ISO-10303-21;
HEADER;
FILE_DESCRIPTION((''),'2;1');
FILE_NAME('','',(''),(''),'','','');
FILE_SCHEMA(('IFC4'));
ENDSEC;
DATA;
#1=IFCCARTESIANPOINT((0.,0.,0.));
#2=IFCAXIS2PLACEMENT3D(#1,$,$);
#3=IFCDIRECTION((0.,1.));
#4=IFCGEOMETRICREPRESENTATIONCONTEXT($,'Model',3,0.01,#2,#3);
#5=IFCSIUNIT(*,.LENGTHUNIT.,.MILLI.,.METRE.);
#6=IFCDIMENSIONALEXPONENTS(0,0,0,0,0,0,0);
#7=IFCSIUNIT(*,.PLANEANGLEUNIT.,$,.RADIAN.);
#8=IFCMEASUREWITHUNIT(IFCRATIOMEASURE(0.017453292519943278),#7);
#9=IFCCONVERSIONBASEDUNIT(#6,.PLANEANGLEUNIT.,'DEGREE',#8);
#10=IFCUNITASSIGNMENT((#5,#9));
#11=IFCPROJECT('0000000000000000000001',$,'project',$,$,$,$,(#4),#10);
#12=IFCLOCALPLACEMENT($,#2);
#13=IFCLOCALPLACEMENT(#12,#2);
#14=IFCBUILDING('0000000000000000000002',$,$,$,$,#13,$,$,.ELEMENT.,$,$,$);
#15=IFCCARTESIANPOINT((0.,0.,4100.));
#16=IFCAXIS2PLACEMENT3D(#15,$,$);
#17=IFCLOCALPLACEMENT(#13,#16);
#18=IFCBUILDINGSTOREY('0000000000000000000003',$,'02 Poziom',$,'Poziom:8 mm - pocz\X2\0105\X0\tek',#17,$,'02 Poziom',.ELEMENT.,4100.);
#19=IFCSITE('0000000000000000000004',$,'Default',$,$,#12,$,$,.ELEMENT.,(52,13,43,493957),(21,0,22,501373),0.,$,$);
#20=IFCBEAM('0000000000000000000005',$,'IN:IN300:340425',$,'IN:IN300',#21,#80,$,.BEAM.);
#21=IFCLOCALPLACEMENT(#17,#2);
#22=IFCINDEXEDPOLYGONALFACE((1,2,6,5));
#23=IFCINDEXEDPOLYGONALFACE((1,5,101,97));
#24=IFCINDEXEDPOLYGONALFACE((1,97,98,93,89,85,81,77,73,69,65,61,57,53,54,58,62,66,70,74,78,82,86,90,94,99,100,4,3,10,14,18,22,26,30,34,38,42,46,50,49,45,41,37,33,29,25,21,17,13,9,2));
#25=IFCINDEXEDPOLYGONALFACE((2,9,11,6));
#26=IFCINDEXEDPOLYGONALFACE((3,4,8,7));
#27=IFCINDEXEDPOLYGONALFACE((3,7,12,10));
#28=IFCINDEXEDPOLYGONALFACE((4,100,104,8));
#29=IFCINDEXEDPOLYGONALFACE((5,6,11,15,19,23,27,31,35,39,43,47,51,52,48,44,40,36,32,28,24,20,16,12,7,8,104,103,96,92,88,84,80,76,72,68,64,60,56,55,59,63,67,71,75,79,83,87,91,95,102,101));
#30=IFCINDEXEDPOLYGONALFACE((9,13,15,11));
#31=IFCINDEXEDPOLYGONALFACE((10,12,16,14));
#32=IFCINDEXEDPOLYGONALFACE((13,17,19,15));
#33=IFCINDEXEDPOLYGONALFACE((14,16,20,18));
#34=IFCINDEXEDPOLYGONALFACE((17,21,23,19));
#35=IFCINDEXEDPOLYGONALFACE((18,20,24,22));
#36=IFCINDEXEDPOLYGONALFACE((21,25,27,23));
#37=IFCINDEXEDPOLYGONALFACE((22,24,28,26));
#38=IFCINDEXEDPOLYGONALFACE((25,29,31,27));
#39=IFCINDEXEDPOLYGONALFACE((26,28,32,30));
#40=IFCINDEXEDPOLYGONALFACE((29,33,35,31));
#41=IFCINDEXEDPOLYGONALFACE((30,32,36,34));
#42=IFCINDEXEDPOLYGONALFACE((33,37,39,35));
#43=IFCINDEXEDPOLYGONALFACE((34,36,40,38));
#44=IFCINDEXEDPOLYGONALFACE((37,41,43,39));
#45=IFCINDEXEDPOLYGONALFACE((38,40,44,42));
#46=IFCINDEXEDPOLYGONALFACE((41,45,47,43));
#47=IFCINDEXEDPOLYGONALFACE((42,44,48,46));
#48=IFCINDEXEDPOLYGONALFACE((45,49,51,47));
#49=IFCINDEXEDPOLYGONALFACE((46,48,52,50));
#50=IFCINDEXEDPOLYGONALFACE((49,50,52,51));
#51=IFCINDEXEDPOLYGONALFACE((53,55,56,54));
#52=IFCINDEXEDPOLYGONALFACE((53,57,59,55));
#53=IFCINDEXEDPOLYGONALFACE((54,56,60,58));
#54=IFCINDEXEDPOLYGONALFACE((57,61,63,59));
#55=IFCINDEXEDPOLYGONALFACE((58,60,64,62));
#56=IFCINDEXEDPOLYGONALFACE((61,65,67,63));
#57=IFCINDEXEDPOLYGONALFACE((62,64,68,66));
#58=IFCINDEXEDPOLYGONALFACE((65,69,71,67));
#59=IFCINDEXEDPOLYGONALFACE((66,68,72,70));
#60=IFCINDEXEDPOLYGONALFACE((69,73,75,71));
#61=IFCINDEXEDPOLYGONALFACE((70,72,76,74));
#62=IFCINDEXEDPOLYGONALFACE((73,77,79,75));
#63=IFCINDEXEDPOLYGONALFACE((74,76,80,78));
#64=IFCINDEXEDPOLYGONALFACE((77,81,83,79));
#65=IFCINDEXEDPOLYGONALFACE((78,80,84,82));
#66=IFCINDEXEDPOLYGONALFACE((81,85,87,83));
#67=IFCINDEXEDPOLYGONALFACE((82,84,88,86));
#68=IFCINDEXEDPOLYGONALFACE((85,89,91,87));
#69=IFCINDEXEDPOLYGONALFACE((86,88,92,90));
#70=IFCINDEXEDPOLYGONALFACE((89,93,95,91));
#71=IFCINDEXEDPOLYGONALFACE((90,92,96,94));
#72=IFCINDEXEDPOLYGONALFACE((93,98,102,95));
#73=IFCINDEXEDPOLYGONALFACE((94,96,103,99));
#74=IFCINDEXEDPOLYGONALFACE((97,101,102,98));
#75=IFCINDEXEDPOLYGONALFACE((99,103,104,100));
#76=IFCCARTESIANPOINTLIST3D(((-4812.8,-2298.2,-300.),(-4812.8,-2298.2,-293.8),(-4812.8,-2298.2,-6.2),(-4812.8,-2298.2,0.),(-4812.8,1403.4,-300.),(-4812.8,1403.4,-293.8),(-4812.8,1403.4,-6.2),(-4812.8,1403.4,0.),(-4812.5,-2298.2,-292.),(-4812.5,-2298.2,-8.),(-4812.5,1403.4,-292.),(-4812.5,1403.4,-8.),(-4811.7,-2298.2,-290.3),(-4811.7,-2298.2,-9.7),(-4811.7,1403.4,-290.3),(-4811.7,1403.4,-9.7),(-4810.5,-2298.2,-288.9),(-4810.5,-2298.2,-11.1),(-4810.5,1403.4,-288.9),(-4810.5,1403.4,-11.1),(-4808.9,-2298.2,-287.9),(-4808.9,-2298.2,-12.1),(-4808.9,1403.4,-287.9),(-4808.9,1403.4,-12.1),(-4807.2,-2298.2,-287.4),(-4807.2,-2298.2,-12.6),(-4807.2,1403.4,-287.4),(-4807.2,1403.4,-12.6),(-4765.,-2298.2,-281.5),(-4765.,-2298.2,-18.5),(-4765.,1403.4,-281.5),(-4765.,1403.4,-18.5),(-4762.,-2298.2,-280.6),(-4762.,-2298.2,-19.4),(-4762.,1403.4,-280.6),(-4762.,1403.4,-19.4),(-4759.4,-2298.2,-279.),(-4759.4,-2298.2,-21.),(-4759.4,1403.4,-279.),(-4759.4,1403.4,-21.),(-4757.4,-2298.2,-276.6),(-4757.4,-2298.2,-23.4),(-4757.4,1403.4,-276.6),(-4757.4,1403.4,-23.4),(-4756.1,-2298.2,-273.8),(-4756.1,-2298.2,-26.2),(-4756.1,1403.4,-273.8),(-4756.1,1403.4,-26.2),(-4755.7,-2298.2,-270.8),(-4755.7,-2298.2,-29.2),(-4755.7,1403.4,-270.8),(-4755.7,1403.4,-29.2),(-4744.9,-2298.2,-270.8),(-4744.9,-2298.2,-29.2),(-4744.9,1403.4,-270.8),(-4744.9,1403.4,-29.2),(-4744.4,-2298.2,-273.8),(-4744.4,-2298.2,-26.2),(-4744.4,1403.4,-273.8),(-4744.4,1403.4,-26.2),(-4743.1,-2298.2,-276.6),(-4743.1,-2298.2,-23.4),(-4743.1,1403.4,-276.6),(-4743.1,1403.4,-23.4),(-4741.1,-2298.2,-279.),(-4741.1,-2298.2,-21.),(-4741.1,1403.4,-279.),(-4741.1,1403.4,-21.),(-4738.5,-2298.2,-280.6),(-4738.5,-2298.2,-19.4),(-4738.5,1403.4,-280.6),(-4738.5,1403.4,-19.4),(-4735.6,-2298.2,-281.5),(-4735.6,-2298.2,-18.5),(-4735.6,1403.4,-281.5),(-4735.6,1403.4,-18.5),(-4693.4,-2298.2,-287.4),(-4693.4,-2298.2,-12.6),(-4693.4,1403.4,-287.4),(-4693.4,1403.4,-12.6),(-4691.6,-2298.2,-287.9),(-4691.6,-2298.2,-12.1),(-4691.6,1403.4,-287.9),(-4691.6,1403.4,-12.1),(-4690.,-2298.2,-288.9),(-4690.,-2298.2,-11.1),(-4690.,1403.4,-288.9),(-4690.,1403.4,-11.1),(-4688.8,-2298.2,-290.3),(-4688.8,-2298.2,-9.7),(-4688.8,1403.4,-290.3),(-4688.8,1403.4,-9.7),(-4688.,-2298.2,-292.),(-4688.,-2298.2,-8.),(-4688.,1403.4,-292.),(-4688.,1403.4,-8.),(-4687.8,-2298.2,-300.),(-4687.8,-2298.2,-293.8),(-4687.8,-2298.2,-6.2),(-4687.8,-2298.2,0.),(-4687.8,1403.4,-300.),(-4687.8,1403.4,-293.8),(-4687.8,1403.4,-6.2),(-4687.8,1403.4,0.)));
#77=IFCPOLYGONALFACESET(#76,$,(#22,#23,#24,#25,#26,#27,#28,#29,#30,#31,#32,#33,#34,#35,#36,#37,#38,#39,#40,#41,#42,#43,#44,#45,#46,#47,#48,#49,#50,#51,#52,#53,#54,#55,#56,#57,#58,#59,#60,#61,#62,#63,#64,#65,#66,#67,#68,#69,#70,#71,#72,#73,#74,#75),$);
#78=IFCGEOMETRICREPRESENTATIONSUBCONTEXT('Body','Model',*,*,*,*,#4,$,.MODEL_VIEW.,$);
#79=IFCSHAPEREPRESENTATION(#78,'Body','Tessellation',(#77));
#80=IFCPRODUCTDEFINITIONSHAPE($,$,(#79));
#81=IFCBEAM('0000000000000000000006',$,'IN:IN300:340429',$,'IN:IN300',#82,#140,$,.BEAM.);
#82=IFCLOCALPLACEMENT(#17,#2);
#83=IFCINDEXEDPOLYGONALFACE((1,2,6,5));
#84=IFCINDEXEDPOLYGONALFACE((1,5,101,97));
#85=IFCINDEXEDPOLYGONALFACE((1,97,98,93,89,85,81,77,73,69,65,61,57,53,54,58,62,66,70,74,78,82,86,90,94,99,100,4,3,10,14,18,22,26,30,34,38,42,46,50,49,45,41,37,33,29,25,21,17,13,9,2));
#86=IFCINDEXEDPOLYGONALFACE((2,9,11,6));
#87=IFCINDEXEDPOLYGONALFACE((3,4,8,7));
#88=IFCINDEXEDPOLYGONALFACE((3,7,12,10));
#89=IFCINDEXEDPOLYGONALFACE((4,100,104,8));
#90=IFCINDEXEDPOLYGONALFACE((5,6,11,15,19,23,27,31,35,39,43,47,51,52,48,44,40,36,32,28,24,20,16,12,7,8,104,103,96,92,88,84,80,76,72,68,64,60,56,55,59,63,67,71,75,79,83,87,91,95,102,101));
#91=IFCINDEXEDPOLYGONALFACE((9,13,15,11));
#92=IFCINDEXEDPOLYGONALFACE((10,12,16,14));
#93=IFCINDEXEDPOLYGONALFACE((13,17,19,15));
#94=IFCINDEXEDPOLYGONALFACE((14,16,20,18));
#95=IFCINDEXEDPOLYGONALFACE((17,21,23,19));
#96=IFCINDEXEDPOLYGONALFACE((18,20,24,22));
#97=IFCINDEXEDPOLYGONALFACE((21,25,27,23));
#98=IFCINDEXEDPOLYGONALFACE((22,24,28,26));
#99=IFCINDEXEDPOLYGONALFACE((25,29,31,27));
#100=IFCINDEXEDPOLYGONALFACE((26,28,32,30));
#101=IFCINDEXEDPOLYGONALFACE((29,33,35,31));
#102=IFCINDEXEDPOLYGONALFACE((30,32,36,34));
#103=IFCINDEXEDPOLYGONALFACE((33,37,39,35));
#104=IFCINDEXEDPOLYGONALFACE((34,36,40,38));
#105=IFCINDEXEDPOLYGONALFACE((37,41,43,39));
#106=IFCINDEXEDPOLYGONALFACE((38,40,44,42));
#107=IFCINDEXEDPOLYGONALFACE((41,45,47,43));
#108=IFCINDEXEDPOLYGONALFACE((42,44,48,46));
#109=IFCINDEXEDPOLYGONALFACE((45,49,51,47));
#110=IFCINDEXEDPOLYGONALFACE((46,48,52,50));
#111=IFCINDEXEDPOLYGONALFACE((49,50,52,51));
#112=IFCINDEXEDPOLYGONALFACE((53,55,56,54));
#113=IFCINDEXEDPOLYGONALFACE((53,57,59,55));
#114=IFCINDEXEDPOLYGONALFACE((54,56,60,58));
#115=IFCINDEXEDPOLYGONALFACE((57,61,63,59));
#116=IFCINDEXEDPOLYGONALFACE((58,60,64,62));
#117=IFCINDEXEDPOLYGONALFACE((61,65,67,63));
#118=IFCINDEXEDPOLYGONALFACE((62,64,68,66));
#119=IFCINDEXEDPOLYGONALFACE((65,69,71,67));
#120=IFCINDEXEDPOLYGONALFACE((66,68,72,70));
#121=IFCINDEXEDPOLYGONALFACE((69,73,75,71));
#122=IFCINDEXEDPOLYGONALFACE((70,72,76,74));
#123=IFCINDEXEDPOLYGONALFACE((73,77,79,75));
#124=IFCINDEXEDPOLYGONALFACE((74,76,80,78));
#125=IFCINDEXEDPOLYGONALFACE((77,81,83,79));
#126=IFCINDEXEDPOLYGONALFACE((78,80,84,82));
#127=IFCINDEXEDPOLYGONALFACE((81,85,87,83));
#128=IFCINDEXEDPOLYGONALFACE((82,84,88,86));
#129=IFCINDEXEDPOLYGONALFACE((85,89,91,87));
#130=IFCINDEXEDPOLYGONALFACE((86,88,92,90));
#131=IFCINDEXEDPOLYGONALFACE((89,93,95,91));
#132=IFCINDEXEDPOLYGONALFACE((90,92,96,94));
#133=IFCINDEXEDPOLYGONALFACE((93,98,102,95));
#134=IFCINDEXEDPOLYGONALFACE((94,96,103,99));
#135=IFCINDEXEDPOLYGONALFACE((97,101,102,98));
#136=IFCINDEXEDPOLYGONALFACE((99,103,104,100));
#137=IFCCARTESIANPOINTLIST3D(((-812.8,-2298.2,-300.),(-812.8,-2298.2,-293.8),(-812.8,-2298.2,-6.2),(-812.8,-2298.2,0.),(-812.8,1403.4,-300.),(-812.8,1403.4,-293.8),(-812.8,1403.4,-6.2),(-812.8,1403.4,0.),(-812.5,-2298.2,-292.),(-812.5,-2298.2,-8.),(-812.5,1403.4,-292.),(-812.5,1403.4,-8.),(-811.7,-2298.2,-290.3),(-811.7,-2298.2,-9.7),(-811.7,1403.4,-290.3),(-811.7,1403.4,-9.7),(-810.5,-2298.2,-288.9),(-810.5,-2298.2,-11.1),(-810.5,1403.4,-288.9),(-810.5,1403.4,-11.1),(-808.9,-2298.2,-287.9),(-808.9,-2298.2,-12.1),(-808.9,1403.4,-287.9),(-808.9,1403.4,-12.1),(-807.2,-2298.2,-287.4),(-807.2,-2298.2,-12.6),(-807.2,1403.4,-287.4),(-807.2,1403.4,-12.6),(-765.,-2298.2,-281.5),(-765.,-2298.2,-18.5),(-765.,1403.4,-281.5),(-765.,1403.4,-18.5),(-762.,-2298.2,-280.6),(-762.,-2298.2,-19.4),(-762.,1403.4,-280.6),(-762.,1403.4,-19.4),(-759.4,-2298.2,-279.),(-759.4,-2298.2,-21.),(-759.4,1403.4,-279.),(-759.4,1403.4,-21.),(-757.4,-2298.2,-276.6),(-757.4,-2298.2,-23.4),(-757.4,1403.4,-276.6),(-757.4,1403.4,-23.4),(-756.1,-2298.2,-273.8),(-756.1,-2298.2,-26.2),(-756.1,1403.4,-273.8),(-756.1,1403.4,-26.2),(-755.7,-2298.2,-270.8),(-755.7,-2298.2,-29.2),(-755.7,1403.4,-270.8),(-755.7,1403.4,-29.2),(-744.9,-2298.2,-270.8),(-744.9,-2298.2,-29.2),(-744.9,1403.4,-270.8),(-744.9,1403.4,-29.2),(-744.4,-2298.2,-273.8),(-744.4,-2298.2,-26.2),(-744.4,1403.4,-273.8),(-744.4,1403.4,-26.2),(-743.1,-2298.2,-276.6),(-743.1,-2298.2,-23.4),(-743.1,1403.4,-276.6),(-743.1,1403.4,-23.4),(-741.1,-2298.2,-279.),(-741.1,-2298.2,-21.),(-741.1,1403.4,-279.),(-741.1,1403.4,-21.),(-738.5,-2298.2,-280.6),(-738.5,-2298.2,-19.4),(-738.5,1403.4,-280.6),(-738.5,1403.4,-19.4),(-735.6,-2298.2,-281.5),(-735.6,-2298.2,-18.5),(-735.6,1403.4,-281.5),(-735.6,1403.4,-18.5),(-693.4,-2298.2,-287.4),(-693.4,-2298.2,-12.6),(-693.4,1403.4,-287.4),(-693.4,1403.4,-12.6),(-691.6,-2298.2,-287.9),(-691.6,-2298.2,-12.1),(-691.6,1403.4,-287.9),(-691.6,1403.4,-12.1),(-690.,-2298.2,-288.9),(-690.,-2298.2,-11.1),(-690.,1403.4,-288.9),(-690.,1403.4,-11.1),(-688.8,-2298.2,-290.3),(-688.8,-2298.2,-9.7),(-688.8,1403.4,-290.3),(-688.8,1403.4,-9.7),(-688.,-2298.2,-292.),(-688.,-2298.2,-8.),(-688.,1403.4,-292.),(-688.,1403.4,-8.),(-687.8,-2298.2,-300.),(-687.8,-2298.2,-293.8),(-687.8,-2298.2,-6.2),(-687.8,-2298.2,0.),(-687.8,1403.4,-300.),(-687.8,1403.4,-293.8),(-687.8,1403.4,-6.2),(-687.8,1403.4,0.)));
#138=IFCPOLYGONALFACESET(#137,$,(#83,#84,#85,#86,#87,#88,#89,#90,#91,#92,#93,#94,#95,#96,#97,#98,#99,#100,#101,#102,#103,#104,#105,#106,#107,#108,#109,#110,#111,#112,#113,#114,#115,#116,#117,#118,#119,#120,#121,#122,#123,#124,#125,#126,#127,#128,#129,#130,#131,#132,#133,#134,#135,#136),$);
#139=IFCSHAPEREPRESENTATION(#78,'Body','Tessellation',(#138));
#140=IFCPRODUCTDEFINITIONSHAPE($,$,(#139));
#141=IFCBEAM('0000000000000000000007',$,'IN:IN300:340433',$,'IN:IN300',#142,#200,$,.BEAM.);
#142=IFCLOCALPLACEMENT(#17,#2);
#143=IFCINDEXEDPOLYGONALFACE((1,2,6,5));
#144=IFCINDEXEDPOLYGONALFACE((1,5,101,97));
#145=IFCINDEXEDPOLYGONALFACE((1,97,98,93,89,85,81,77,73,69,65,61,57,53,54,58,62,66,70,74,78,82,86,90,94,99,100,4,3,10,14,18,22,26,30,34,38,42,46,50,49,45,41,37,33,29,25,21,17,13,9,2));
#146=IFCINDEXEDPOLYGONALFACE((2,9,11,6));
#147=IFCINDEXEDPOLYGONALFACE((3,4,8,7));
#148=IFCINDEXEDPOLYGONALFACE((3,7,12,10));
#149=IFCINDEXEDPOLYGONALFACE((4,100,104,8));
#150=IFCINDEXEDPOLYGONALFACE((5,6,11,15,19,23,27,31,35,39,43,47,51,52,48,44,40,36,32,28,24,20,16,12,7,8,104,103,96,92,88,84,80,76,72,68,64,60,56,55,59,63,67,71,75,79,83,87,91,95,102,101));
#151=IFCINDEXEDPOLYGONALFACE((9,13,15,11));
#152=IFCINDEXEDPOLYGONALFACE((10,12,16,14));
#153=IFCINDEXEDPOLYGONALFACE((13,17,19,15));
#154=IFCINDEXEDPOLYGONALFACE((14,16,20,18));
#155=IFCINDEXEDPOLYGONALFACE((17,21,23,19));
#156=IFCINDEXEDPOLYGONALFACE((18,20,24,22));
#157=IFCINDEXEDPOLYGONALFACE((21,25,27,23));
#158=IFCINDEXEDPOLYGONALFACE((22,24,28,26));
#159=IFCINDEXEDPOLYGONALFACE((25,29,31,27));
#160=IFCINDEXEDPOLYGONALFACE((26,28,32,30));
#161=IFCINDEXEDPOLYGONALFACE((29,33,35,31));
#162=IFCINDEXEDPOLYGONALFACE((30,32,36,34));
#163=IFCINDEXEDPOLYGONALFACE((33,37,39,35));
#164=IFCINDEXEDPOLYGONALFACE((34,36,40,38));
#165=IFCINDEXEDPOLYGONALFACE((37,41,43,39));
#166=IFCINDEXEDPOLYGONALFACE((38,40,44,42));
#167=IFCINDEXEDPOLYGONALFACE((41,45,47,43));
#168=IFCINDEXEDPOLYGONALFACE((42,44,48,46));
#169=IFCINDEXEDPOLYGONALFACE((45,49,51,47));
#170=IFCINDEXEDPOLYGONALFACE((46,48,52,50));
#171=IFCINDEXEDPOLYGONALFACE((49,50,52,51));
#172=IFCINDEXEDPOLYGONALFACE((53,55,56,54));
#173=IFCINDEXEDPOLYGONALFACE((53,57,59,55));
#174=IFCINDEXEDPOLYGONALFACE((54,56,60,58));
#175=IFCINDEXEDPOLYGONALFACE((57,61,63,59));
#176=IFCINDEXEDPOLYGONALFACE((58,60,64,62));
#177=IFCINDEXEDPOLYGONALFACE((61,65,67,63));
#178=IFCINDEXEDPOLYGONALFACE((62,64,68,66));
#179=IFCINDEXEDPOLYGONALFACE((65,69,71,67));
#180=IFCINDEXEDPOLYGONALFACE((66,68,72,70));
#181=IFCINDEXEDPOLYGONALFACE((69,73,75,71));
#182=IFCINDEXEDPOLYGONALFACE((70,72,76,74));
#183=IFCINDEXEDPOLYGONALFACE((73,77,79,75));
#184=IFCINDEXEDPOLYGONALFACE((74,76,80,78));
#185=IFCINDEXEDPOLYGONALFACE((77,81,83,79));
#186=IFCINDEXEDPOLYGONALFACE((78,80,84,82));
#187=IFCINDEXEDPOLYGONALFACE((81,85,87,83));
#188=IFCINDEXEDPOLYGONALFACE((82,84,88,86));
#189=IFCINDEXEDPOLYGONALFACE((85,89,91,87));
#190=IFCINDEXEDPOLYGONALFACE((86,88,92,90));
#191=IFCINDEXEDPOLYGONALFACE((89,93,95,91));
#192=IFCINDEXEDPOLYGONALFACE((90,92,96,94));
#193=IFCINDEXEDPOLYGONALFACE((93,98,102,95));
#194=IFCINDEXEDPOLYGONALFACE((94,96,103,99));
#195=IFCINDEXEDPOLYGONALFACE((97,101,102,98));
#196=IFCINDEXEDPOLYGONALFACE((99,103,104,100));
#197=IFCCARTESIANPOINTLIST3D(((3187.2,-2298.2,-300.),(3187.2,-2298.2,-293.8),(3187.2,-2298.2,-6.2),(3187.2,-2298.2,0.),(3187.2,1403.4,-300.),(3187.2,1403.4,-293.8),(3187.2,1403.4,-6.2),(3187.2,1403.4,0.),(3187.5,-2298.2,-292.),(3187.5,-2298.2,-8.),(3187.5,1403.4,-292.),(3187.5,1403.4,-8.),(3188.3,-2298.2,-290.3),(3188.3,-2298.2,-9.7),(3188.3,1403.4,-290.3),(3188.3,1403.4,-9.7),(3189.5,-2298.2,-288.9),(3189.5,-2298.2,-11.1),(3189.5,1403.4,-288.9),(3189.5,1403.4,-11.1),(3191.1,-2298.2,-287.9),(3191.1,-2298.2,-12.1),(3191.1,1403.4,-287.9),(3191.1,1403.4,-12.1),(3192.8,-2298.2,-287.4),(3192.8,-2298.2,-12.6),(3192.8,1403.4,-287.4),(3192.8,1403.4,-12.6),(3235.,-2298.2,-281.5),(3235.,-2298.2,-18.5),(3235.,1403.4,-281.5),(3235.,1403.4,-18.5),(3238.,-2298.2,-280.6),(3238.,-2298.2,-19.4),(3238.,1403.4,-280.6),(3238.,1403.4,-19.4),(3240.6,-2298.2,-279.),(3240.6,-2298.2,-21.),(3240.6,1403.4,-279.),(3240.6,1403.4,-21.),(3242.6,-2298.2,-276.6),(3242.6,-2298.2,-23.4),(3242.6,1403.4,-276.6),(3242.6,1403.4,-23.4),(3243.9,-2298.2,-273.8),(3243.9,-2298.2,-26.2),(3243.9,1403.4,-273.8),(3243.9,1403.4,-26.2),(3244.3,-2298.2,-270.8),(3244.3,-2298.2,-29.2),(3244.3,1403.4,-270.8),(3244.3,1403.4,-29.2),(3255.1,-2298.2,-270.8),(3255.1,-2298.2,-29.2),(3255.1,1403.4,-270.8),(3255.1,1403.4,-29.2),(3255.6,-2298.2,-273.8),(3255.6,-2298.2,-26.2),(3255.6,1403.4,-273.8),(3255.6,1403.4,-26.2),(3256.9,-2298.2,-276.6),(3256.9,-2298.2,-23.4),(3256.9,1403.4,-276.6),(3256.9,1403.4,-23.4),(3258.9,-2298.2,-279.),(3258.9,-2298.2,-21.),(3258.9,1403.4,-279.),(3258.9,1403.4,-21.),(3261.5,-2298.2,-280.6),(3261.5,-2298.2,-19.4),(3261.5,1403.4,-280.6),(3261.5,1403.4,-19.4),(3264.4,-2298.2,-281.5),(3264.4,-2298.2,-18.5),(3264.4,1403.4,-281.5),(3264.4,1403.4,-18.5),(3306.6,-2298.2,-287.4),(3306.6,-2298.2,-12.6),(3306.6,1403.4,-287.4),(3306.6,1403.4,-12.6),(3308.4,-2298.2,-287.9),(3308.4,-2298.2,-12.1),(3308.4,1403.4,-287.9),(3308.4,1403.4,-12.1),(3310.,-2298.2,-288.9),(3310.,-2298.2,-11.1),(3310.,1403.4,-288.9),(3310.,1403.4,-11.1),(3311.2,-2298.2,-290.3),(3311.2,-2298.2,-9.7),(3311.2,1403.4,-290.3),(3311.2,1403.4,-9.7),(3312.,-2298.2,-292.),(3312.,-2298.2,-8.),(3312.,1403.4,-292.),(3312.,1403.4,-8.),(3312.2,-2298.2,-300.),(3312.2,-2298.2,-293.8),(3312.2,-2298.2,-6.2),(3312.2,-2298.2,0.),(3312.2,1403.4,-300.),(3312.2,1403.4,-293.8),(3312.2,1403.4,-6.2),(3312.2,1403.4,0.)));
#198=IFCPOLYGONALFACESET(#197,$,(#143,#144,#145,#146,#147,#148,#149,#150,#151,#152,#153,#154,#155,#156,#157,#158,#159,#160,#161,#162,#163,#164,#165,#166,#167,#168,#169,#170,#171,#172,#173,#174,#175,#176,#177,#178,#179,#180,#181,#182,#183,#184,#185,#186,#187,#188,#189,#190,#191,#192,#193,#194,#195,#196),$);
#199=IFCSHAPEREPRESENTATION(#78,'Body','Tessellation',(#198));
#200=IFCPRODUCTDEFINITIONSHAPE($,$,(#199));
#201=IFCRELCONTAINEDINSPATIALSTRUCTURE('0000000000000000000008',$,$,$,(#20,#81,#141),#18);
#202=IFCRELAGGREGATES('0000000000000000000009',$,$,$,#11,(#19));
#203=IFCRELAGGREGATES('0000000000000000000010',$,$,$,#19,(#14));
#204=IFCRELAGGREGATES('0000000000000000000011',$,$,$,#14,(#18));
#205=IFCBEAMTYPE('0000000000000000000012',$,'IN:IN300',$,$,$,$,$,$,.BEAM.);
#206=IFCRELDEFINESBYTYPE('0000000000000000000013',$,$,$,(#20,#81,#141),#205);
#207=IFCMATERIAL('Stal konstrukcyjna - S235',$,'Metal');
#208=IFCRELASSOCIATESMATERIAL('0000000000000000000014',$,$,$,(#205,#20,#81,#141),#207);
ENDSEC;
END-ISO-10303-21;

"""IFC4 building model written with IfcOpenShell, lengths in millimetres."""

from ifc_helpers import new_model, entity, si_unit, converted_unit, direction, frame, origin, place, context, subcontext, project, spatial, line, arc, indexed_curve, outline, extrude, source, transform, mapped, material, type_object, type_shapes, element, save


model = new_model("IFC4")

# Units and contexts
model_context = context("Model", 3, precision=0.01, world=origin(), true_north=direction((0.0, 1.0)))
body_context = subcontext(model_context, "Body", "Model", "MODEL_VIEW")
ifc_project = project(units=[si_unit("LENGTHUNIT", "METRE", prefix="MILLI"), converted_unit("PLANEANGLEUNIT", "DEGREE", entity("IfcRatioMeasure", 0.017453292519943278), si_unit("PLANEANGLEUNIT", "RADIAN"), dimensions=[0, 0, 0, 0, 0, 0, 0])], contexts=[model_context])

# Site, building, storey
site_placement = place(None, origin())
site = spatial("IfcSite", under=ifc_project, at=site_placement, Name="Default", CompositionType="ELEMENT", RefLatitude=(52, 13, 43, 493957), RefLongitude=(21, 0, 22, 501373), RefElevation=0.0)
building_placement = place(site_placement, origin())
building = spatial("IfcBuilding", under=site, at=building_placement, CompositionType="ELEMENT")
storey_placement = place(building_placement, frame((0.0, 0.0, 4100.0)))
storey = spatial("IfcBuildingStorey", under=building, at=storey_placement, Name="02 Poziom", ObjectType="Poziom:8 mm - początek", LongName="02 Poziom", CompositionType="ELEMENT", Elevation=4100.0)

# Shared definitions
ifc_material_1 = material(Name="Stal konstrukcyjna - S235", Category="Metal")

# Beams
beam_type_1 = type_object("IfcBeamType", Name="IN:IN300", PredefinedType="BEAM", material=ifc_material_1)
shared_shape_1 = source(origin(), body_context, "Body", "SweptSolid", [
    extrude(outline(indexed_curve([(143.8, -62.5), (150.0, -62.5), (150.0, 62.5), (143.8, 62.5), (139.6, 60.9), (137.4, 56.9), (131.5, 14.7), (127.9, 8.1), (120.8, 5.4), (-120.8, 5.4), (-127.9, 8.1), (-131.5, 14.7), (-137.4, 56.9), (-139.6, 60.9), (-143.8, 62.5), (-150.0, 62.5), (-150.0, -62.5), (-143.8, -62.5), (-139.6, -60.9), (-137.4, -56.9), (-131.5, -14.7), (-127.9, -8.1), (-120.8, -5.4), (120.8, -5.4), (127.9, -8.1), (131.5, -14.7), (137.4, -56.9), (139.6, -60.9)], segments=[line(1, 2, 3, 4), arc(4, 5, 6), line(6, 7), arc(7, 8, 9), line(9, 10), arc(10, 11, 12), line(12, 13), arc(13, 14, 15), line(15, 16, 17, 18), arc(18, 19, 20), line(20, 21), arc(21, 22, 23), line(23, 24), arc(24, 25, 26), line(26, 27), arc(27, 28, 1)], self_intersect=False)), frame((-1850.8, 0.0, 0.0), z_axis=(1.0, 0.0, 0.0), x_axis=(0.0, 0.0, -1.0)), (0.0, 0.0, 1.0), 3701.6),
])
type_shapes(beam_type_1, [shared_shape_1])
for number, where, z_axis, x_axis, name in (
    (1, (-4750.3, -447.4, -150.0), (0.0, 0.0, 1.0), (0.0, -1.0, 0.0), "IN:IN300:340425"),
    (2, (-750.3, -447.4, -150.0), (0.0, 0.0, 1.0), (0.0, -1.0, 0.0), "IN:IN300:340429"),
    (3, (3249.7, -447.4, -150.0), (0.0, 0.0, 1.0), (0.0, -1.0, 0.0), "IN:IN300:340433"),
):
    element("IfcBeam", number, at=place(storey_placement, frame(where, z_axis=z_axis, x_axis=x_axis)), inside=storey, type_object=beam_type_1, material=ifc_material_1, Name=name, ObjectType="IN:IN300", PredefinedType="BEAM", context=body_context, shape_type="MappedRepresentation", body=[
        mapped(shared_shape_1, transform((0.0, 0.0, 0.0), scale=1.0)),
    ])

save(model, "model.ifc")
